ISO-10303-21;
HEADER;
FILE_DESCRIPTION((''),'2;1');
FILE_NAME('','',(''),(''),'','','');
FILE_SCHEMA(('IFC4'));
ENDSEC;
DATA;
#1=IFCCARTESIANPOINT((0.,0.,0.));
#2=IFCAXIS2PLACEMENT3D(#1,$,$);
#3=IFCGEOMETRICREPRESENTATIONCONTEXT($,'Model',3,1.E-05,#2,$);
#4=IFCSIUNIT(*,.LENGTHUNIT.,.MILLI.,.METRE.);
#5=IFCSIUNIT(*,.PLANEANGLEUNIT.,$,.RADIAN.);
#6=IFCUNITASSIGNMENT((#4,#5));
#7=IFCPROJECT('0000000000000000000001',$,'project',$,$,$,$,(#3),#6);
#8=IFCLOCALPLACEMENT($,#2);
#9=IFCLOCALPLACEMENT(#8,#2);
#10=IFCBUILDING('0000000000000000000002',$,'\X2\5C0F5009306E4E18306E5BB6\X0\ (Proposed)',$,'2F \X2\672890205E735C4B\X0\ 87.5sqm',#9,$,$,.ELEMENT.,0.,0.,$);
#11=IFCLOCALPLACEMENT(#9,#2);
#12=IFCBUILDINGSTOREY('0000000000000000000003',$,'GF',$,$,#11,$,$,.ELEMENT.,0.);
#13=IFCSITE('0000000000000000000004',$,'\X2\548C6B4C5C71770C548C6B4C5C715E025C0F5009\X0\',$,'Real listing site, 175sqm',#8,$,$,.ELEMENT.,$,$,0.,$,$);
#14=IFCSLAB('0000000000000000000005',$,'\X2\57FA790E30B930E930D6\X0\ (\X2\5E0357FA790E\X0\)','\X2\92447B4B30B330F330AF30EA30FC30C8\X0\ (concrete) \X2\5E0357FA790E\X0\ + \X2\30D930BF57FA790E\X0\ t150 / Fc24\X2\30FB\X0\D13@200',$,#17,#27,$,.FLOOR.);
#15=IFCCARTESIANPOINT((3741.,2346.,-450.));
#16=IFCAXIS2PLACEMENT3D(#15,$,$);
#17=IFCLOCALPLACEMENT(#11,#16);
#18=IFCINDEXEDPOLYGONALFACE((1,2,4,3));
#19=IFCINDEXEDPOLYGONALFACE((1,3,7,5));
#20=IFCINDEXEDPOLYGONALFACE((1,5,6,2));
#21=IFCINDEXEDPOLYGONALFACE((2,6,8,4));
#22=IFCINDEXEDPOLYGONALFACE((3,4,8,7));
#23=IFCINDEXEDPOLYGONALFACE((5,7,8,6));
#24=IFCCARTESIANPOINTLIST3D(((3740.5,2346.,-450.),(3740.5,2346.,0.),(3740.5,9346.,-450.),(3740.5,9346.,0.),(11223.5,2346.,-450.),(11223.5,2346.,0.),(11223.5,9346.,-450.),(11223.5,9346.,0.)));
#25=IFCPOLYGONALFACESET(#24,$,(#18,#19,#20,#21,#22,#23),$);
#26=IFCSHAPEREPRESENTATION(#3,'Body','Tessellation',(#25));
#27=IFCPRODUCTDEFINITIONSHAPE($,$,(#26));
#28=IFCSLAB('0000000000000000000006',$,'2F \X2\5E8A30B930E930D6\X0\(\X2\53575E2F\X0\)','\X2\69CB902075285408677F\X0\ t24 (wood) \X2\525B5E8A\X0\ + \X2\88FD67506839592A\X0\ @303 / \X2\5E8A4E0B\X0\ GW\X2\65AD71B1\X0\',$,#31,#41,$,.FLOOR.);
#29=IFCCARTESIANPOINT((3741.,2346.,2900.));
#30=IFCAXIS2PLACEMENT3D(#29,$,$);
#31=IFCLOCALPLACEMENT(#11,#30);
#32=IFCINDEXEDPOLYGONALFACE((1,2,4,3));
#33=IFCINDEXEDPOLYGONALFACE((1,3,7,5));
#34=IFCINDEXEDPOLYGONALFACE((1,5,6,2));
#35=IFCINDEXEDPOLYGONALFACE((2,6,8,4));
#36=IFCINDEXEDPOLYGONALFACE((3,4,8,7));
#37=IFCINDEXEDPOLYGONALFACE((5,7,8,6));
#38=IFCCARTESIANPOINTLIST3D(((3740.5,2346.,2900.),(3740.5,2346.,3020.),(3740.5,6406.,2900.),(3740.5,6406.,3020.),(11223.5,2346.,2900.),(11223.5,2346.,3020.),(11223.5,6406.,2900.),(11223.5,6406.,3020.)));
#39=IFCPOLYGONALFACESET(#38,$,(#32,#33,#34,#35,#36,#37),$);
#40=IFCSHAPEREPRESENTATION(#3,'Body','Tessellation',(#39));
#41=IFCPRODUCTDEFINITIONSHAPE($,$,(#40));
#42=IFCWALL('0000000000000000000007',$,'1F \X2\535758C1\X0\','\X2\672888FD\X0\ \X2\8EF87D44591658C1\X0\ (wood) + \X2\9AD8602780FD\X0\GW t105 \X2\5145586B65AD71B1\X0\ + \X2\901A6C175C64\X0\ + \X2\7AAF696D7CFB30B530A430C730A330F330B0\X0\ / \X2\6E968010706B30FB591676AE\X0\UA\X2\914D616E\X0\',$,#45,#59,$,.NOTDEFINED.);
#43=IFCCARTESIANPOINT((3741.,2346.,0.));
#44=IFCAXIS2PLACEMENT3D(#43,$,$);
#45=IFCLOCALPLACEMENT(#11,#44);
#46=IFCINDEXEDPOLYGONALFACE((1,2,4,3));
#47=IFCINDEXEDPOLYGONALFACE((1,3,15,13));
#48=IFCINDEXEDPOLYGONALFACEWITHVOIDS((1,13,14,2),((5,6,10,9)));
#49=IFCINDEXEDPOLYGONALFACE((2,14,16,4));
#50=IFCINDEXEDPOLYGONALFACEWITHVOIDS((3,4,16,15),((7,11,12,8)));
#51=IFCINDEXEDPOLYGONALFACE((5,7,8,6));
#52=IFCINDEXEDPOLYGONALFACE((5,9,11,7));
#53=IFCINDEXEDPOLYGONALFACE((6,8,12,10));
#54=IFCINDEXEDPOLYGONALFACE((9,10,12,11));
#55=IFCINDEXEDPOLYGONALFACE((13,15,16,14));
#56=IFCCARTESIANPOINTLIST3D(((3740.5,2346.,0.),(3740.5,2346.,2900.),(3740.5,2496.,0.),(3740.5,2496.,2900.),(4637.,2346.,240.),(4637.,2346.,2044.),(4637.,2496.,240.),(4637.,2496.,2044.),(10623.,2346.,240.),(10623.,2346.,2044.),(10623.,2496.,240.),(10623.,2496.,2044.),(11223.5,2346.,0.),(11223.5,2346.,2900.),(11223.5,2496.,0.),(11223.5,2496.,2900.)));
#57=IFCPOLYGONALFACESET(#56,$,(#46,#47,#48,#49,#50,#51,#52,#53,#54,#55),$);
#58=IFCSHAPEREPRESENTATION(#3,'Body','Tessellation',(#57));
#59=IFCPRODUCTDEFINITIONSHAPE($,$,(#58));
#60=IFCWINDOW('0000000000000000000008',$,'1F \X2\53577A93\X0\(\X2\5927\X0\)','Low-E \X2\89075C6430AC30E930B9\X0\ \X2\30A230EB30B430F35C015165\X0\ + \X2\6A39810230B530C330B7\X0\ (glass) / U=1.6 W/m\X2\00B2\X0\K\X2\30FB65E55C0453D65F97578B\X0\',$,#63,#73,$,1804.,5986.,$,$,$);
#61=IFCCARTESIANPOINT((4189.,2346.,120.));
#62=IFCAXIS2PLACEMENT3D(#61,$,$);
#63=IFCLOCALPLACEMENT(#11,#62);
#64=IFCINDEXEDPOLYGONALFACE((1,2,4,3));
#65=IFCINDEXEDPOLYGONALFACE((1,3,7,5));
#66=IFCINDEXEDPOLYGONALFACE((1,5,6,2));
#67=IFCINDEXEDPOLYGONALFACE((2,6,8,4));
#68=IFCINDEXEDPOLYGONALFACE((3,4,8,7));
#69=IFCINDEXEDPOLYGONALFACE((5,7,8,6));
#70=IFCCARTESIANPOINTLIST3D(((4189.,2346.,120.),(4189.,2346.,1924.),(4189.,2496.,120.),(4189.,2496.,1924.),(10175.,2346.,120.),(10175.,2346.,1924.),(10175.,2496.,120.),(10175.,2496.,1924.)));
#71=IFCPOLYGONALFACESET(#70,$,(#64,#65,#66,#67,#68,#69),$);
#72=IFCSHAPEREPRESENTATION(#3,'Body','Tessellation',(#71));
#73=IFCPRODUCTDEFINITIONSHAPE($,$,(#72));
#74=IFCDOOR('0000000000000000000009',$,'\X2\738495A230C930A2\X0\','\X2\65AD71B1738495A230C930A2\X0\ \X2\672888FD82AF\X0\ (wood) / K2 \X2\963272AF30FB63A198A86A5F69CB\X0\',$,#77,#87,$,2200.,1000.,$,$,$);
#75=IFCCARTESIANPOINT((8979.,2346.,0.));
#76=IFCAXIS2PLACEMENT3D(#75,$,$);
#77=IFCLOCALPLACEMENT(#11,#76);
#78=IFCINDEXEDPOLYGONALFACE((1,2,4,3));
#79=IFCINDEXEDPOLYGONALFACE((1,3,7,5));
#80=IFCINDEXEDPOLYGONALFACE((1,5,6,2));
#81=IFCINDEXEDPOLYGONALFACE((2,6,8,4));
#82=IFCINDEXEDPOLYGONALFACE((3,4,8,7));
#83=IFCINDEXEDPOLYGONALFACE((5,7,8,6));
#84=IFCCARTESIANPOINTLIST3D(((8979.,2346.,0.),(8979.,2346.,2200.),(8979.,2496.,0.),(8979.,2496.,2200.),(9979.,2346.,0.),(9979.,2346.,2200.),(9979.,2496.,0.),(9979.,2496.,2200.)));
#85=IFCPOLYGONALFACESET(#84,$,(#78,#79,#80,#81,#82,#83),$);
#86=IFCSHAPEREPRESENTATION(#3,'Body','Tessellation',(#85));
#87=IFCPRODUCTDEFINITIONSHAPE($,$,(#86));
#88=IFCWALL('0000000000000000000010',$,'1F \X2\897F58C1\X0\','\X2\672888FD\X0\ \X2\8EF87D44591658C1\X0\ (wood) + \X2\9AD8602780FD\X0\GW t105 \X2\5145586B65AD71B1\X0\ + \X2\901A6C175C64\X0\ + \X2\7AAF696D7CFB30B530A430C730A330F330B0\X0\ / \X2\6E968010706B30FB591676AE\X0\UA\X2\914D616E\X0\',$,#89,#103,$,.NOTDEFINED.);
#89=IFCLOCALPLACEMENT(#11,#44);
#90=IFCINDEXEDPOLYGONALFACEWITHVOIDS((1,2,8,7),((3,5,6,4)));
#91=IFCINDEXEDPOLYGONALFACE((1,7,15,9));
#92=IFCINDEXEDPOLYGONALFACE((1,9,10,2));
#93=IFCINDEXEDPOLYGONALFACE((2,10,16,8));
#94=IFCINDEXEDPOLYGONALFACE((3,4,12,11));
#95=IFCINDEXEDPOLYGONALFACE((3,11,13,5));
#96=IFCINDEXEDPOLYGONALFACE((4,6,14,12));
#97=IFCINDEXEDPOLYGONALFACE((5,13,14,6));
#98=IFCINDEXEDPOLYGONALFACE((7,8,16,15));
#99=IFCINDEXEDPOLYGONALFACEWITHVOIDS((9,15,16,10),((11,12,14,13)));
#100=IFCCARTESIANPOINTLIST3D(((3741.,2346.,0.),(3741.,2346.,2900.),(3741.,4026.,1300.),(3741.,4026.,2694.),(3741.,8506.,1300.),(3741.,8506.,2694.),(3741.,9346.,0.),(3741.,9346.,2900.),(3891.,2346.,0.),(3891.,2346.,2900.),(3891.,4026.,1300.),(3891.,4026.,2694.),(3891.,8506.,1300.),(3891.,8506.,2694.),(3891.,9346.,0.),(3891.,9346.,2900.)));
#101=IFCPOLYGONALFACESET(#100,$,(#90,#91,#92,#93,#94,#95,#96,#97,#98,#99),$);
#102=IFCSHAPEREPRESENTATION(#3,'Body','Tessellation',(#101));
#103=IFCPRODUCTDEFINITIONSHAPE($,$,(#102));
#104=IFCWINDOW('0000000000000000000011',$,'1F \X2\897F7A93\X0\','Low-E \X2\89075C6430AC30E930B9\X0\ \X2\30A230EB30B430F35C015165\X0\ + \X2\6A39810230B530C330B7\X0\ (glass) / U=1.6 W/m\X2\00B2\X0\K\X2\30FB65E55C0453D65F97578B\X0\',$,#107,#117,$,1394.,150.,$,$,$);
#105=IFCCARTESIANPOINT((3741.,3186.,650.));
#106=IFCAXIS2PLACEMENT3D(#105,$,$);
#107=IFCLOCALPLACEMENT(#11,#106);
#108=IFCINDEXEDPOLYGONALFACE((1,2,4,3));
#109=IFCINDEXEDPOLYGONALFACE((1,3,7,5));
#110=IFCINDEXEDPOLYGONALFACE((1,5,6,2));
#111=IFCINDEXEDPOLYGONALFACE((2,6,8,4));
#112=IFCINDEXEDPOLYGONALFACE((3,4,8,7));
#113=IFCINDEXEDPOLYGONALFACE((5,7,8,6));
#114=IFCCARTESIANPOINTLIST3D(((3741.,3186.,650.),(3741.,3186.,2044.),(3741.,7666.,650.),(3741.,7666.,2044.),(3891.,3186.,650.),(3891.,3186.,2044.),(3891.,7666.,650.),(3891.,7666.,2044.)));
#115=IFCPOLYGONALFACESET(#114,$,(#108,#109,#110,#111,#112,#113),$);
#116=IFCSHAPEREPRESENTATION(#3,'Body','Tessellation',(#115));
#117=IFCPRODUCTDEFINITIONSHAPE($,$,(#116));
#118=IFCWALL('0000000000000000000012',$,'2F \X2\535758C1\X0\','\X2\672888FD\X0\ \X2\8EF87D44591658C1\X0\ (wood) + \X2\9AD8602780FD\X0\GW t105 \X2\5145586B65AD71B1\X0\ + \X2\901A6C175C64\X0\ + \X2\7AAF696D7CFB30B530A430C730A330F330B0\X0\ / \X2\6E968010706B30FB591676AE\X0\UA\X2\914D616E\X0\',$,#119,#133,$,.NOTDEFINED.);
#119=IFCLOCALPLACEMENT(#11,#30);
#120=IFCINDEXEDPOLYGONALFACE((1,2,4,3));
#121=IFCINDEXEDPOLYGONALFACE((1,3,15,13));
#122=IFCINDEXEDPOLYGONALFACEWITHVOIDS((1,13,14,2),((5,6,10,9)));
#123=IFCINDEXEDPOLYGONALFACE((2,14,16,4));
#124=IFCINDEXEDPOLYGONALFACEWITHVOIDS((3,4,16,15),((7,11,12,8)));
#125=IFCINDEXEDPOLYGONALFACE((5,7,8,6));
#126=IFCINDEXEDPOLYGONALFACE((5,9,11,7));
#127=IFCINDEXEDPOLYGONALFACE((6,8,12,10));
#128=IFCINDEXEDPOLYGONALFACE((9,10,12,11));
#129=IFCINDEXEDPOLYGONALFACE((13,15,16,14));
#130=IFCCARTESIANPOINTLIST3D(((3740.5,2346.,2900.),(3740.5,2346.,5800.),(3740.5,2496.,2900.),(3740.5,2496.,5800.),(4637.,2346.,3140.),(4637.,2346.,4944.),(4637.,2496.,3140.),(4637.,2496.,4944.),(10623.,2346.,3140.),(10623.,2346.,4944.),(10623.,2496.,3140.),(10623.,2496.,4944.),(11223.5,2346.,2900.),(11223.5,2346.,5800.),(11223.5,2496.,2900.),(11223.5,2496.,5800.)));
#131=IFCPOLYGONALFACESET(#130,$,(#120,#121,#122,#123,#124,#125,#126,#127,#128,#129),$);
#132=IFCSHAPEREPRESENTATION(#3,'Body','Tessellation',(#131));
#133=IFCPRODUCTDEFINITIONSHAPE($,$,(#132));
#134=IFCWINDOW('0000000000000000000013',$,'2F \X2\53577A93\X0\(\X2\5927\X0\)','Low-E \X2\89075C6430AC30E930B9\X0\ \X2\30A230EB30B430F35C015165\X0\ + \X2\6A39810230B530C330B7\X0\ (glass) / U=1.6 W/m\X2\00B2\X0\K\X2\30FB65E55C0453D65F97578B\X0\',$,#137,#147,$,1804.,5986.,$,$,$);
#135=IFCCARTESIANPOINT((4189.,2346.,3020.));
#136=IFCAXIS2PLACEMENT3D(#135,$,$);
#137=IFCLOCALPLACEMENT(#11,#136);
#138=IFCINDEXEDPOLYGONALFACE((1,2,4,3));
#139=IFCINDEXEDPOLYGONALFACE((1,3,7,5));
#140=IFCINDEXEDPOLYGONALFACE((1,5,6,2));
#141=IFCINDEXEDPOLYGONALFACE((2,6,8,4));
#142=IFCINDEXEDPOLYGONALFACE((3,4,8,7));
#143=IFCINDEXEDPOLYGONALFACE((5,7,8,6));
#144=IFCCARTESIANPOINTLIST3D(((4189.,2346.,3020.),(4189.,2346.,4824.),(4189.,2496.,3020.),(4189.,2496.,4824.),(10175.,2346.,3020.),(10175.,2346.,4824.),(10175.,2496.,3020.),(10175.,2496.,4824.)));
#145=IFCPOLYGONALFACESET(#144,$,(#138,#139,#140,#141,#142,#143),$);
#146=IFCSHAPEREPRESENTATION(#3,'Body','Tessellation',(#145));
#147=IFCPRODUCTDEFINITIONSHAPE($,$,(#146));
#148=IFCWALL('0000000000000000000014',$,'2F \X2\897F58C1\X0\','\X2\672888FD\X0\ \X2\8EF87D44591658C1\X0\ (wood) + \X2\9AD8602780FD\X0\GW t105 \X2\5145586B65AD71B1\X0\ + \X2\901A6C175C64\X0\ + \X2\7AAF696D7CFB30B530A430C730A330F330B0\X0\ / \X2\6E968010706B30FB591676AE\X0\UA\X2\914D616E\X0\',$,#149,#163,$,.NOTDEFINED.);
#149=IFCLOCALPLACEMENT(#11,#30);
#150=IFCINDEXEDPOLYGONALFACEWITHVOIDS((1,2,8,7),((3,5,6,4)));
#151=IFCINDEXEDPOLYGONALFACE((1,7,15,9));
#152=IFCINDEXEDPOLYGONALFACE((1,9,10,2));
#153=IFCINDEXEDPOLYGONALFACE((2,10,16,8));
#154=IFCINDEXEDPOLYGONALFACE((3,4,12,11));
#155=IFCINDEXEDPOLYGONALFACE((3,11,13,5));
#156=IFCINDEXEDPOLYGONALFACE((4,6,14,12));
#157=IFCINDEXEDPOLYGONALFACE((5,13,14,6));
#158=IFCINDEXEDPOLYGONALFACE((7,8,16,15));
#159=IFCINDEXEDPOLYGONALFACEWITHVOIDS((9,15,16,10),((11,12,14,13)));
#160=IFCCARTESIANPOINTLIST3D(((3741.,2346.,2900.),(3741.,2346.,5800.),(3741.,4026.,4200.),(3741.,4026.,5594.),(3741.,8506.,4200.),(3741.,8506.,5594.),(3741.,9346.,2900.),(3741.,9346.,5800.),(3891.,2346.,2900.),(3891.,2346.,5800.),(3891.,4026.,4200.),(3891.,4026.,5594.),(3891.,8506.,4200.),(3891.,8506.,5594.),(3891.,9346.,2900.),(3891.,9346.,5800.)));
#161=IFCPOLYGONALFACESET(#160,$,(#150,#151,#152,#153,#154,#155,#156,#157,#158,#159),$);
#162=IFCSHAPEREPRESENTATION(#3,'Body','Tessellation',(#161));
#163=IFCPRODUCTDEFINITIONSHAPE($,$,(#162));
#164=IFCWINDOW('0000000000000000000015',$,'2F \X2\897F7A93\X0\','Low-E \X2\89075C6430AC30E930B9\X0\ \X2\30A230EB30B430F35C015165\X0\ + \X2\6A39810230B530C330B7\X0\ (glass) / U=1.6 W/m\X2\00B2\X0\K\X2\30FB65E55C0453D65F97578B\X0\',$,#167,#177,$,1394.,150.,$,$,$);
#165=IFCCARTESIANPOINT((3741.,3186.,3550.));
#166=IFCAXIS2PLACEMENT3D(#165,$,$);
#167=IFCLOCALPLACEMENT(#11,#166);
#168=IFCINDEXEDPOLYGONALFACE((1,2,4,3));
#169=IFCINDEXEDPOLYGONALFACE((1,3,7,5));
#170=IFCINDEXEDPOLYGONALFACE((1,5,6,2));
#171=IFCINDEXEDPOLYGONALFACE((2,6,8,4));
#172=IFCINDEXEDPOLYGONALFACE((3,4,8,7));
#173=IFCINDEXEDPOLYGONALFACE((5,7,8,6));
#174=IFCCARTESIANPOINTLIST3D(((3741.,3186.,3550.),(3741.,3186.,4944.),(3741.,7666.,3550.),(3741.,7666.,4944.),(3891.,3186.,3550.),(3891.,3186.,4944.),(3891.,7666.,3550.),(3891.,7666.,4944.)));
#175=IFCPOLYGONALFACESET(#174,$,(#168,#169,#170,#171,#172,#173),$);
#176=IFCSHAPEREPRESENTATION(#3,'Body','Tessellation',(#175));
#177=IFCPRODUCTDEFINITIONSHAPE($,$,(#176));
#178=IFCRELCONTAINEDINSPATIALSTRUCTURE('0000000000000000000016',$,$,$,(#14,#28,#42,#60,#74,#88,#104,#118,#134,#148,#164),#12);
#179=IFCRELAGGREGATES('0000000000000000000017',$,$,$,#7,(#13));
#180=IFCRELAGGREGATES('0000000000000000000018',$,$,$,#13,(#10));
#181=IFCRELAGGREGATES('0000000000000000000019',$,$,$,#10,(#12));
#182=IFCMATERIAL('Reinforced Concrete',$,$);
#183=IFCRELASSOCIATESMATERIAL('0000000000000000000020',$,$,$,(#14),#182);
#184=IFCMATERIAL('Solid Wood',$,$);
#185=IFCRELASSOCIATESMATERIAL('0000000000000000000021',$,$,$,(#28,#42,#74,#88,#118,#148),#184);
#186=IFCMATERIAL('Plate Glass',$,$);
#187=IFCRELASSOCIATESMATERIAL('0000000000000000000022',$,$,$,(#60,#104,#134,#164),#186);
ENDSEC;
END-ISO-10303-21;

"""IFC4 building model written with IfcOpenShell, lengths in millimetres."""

from ifc_helpers import new_model, si_unit, frame, frame_2d, origin, place, context, project, spatial, rectangle, extrude, material, element, fill, save


model = new_model("IFC4")

# Units and contexts
model_context = context("Model", 3, precision=1e-05, world=origin())
ifc_project = project(units=[si_unit("LENGTHUNIT", "METRE", prefix="MILLI"), si_unit("PLANEANGLEUNIT", "RADIAN")], contexts=[model_context])

# Site, building, storey
site_placement = place(None, origin())
site = spatial("IfcSite", under=ifc_project, at=site_placement, Name="和歌山県和歌山市小倉", ObjectType="Real listing site, 175sqm", CompositionType="ELEMENT", RefElevation=0.0)
building_placement = place(site_placement, origin())
building = spatial("IfcBuilding", under=site, at=building_placement, Name="小倉の丘の家 (Proposed)", ObjectType="2F 木造平屋 87.5sqm", CompositionType="ELEMENT", ElevationOfRefHeight=0.0, ElevationOfTerrain=0.0)
storey_placement = place(building_placement, origin())
storey = spatial("IfcBuildingStorey", under=building, at=storey_placement, Name="GF", CompositionType="ELEMENT", Elevation=0.0)

# Slabs
ifc_material_1 = material(Name="Reinforced Concrete")
slab_1_placement = place(storey_placement, frame((3741.0, 2346.0, -450.0)))
element("IfcSlab", 1, at=slab_1_placement, inside=storey, material=ifc_material_1, Name="基礎スラブ (布基礎)", Description="鉄筋コンクリート (concrete) 布基礎 + ベタ基礎 t150 / Fc24・D13@200", PredefinedType="FLOOR", context=model_context, shape_type="SweptSolid", body=[
    extrude(rectangle(XDim=7483.0, YDim=7000.0, at=frame_2d((3741.0, 3500.0))), frame((3741.0, 2346.0, -450.0)), (0.0, 0.0, 1.0), 450.0),
])
ifc_material_2 = material(Name="Solid Wood")
slab_2_placement = place(storey_placement, frame((3741.0, 2346.0, 2900.0)))
element("IfcSlab", 2, at=slab_2_placement, inside=storey, material=ifc_material_2, Name="2F 床スラブ(南帯)", Description="構造用合板 t24 (wood) 剛床 + 製材根太 @303 / 床下 GW断熱", PredefinedType="FLOOR", context=model_context, shape_type="SweptSolid", body=[
    extrude(rectangle(XDim=7483.0, YDim=4060.0, at=frame_2d((3741.0, 2030.0))), frame((3741.0, 2346.0, 2900.0)), (0.0, 0.0, 1.0), 120.0),
])

# Wall, openings, window, door
wall_1_placement = place(storey_placement, frame((3741.0, 2346.0, 0.0)))
wall_1 = element("IfcWall", 3, at=wall_1_placement, inside=storey, material=ifc_material_2, Name="1F 南壁", Description="木製 軸組外壁 (wood) + 高性能GW t105 充填断熱 + 通気層 + 窯業系サイディング / 準耐火・外皮UA配慮", PredefinedType="NOTDEFINED", context=model_context, shape_type="SweptSolid", body=[
    extrude(rectangle(XDim=7483.0, YDim=150.0, at=frame_2d((3741.0, 75.0))), frame((3741.0, 2346.0, 0.0)), (0.0, 0.0, 1.0), 2900.0),
])
opening_1_placement = place(storey_placement, frame((4189.0, 2346.0, 120.0)))
opening_1 = element("IfcOpeningElement", 4, at=opening_1_placement, cuts=wall_1, PredefinedType="NOTDEFINED", context=model_context, shape_type="SweptSolid", body=[
    extrude(rectangle(XDim=5986.0, YDim=150.0, at=frame_2d((2993.0, 75.0))), frame((4189.0, 2346.0, 120.0)), (0.0, 0.0, 1.0), 1804.0),
])
opening_2_placement = place(storey_placement, frame((8979.0, 2346.0, 0.0)))
opening_2 = element("IfcOpeningElement", 5, at=opening_2_placement, cuts=wall_1, PredefinedType="NOTDEFINED", context=model_context, shape_type="SweptSolid", body=[
    extrude(rectangle(XDim=1000.0, YDim=150.0, at=frame_2d((500.0, 75.0))), frame((8979.0, 2346.0, 0.0)), (0.0, 0.0, 1.0), 2200.0),
])
ifc_material_3 = material(Name="Plate Glass")
window_1_placement = place(storey_placement, frame((4189.0, 2346.0, 120.0)))
window_1 = element("IfcWindow", 6, at=window_1_placement, inside=storey, material=ifc_material_3, Name="1F 南窓(大)", Description="Low-E 複層ガラス アルゴン封入 + 樹脂サッシ (glass) / U=1.6 W/m²K・日射取得型", OverallHeight=1804.0, OverallWidth=5986.0, context=model_context, shape_type="SweptSolid", body=[
    extrude(rectangle(XDim=5986.0, YDim=150.0, at=frame_2d((2993.0, 75.0))), frame((4189.0, 2346.0, 120.0)), (0.0, 0.0, 1.0), 1804.0),
])
fill(opening_1, window_1)
door_placement = place(storey_placement, frame((8979.0, 2346.0, 0.0)))
door = element("IfcDoor", 7, at=door_placement, inside=storey, material=ifc_material_2, Name="玄関ドア", Description="断熱玄関ドア 木製芯 (wood) / K2 防犯・採風機構", OverallHeight=2200.0, OverallWidth=1000.0, context=model_context, shape_type="SweptSolid", body=[
    extrude(rectangle(XDim=1000.0, YDim=150.0, at=frame_2d((500.0, 75.0))), frame((8979.0, 2346.0, 0.0)), (0.0, 0.0, 1.0), 2200.0),
])
fill(opening_2, door)

# Wall, opening, window
wall_2_placement = place(storey_placement, frame((3741.0, 2346.0, 0.0)))
wall_2 = element("IfcWall", 8, at=wall_2_placement, inside=storey, material=ifc_material_2, Name="1F 西壁", Description="木製 軸組外壁 (wood) + 高性能GW t105 充填断熱 + 通気層 + 窯業系サイディング / 準耐火・外皮UA配慮", PredefinedType="NOTDEFINED", context=model_context, shape_type="SweptSolid", body=[
    extrude(rectangle(XDim=150.0, YDim=7000.0, at=frame_2d((75.0, 3500.0))), frame((3741.0, 2346.0, 0.0)), (0.0, 0.0, 1.0), 2900.0),
])
opening_3_placement = place(storey_placement, frame((3741.0, 3186.0, 650.0)))
opening_3 = element("IfcOpeningElement", 9, at=opening_3_placement, cuts=wall_2, PredefinedType="NOTDEFINED", context=model_context, shape_type="SweptSolid", body=[
    extrude(rectangle(XDim=150.0, YDim=4480.0, at=frame_2d((75.0, 2240.0))), frame((3741.0, 3186.0, 650.0)), (0.0, 0.0, 1.0), 1394.0),
])
window_2_placement = place(storey_placement, frame((3741.0, 3186.0, 650.0)))
window_2 = element("IfcWindow", 10, at=window_2_placement, inside=storey, material=ifc_material_3, Name="1F 西窓", Description="Low-E 複層ガラス アルゴン封入 + 樹脂サッシ (glass) / U=1.6 W/m²K・日射取得型", OverallHeight=1394.0, OverallWidth=150.0, context=model_context, shape_type="SweptSolid", body=[
    extrude(rectangle(XDim=150.0, YDim=4480.0, at=frame_2d((75.0, 2240.0))), frame((3741.0, 3186.0, 650.0)), (0.0, 0.0, 1.0), 1394.0),
])
fill(opening_3, window_2)

# Walls, openings, windows
wall_3_placement = place(storey_placement, frame((3741.0, 2346.0, 2900.0)))
wall_3 = element("IfcWall", 11, at=wall_3_placement, inside=storey, material=ifc_material_2, Name="2F 南壁", Description="木製 軸組外壁 (wood) + 高性能GW t105 充填断熱 + 通気層 + 窯業系サイディング / 準耐火・外皮UA配慮", PredefinedType="NOTDEFINED", context=model_context, shape_type="SweptSolid", body=[
    extrude(rectangle(XDim=7483.0, YDim=150.0, at=frame_2d((3741.0, 75.0))), frame((3741.0, 2346.0, 2900.0)), (0.0, 0.0, 1.0), 2900.0),
])
opening_4_placement = place(storey_placement, frame((4189.0, 2346.0, 3020.0)))
opening_4 = element("IfcOpeningElement", 12, at=opening_4_placement, cuts=wall_3, PredefinedType="NOTDEFINED", context=model_context, shape_type="SweptSolid", body=[
    extrude(rectangle(XDim=5986.0, YDim=150.0, at=frame_2d((2993.0, 75.0))), frame((4189.0, 2346.0, 3020.0)), (0.0, 0.0, 1.0), 1804.0),
])
window_3_placement = place(storey_placement, frame((4189.0, 2346.0, 3020.0)))
window_3 = element("IfcWindow", 13, at=window_3_placement, inside=storey, material=ifc_material_3, Name="2F 南窓(大)", Description="Low-E 複層ガラス アルゴン封入 + 樹脂サッシ (glass) / U=1.6 W/m²K・日射取得型", OverallHeight=1804.0, OverallWidth=5986.0, context=model_context, shape_type="SweptSolid", body=[
    extrude(rectangle(XDim=5986.0, YDim=150.0, at=frame_2d((2993.0, 75.0))), frame((4189.0, 2346.0, 3020.0)), (0.0, 0.0, 1.0), 1804.0),
])
fill(opening_4, window_3)
wall_4_placement = place(storey_placement, frame((3741.0, 2346.0, 2900.0)))
wall_4 = element("IfcWall", 14, at=wall_4_placement, inside=storey, material=ifc_material_2, Name="2F 西壁", Description="木製 軸組外壁 (wood) + 高性能GW t105 充填断熱 + 通気層 + 窯業系サイディング / 準耐火・外皮UA配慮", PredefinedType="NOTDEFINED", context=model_context, shape_type="SweptSolid", body=[
    extrude(rectangle(XDim=150.0, YDim=7000.0, at=frame_2d((75.0, 3500.0))), frame((3741.0, 2346.0, 2900.0)), (0.0, 0.0, 1.0), 2900.0),
])
opening_5_placement = place(storey_placement, frame((3741.0, 3186.0, 3550.0)))
opening_5 = element("IfcOpeningElement", 15, at=opening_5_placement, cuts=wall_4, PredefinedType="NOTDEFINED", context=model_context, shape_type="SweptSolid", body=[
    extrude(rectangle(XDim=150.0, YDim=4480.0, at=frame_2d((75.0, 2240.0))), frame((3741.0, 3186.0, 3550.0)), (0.0, 0.0, 1.0), 1394.0),
])
window_4_placement = place(storey_placement, frame((3741.0, 3186.0, 3550.0)))
window_4 = element("IfcWindow", 16, at=window_4_placement, inside=storey, material=ifc_material_3, Name="2F 西窓", Description="Low-E 複層ガラス アルゴン封入 + 樹脂サッシ (glass) / U=1.6 W/m²K・日射取得型", OverallHeight=1394.0, OverallWidth=150.0, context=model_context, shape_type="SweptSolid", body=[
    extrude(rectangle(XDim=150.0, YDim=4480.0, at=frame_2d((75.0, 2240.0))), frame((3741.0, 3186.0, 3550.0)), (0.0, 0.0, 1.0), 1394.0),
])
fill(opening_5, window_4)

save(model, "model.ifc")
